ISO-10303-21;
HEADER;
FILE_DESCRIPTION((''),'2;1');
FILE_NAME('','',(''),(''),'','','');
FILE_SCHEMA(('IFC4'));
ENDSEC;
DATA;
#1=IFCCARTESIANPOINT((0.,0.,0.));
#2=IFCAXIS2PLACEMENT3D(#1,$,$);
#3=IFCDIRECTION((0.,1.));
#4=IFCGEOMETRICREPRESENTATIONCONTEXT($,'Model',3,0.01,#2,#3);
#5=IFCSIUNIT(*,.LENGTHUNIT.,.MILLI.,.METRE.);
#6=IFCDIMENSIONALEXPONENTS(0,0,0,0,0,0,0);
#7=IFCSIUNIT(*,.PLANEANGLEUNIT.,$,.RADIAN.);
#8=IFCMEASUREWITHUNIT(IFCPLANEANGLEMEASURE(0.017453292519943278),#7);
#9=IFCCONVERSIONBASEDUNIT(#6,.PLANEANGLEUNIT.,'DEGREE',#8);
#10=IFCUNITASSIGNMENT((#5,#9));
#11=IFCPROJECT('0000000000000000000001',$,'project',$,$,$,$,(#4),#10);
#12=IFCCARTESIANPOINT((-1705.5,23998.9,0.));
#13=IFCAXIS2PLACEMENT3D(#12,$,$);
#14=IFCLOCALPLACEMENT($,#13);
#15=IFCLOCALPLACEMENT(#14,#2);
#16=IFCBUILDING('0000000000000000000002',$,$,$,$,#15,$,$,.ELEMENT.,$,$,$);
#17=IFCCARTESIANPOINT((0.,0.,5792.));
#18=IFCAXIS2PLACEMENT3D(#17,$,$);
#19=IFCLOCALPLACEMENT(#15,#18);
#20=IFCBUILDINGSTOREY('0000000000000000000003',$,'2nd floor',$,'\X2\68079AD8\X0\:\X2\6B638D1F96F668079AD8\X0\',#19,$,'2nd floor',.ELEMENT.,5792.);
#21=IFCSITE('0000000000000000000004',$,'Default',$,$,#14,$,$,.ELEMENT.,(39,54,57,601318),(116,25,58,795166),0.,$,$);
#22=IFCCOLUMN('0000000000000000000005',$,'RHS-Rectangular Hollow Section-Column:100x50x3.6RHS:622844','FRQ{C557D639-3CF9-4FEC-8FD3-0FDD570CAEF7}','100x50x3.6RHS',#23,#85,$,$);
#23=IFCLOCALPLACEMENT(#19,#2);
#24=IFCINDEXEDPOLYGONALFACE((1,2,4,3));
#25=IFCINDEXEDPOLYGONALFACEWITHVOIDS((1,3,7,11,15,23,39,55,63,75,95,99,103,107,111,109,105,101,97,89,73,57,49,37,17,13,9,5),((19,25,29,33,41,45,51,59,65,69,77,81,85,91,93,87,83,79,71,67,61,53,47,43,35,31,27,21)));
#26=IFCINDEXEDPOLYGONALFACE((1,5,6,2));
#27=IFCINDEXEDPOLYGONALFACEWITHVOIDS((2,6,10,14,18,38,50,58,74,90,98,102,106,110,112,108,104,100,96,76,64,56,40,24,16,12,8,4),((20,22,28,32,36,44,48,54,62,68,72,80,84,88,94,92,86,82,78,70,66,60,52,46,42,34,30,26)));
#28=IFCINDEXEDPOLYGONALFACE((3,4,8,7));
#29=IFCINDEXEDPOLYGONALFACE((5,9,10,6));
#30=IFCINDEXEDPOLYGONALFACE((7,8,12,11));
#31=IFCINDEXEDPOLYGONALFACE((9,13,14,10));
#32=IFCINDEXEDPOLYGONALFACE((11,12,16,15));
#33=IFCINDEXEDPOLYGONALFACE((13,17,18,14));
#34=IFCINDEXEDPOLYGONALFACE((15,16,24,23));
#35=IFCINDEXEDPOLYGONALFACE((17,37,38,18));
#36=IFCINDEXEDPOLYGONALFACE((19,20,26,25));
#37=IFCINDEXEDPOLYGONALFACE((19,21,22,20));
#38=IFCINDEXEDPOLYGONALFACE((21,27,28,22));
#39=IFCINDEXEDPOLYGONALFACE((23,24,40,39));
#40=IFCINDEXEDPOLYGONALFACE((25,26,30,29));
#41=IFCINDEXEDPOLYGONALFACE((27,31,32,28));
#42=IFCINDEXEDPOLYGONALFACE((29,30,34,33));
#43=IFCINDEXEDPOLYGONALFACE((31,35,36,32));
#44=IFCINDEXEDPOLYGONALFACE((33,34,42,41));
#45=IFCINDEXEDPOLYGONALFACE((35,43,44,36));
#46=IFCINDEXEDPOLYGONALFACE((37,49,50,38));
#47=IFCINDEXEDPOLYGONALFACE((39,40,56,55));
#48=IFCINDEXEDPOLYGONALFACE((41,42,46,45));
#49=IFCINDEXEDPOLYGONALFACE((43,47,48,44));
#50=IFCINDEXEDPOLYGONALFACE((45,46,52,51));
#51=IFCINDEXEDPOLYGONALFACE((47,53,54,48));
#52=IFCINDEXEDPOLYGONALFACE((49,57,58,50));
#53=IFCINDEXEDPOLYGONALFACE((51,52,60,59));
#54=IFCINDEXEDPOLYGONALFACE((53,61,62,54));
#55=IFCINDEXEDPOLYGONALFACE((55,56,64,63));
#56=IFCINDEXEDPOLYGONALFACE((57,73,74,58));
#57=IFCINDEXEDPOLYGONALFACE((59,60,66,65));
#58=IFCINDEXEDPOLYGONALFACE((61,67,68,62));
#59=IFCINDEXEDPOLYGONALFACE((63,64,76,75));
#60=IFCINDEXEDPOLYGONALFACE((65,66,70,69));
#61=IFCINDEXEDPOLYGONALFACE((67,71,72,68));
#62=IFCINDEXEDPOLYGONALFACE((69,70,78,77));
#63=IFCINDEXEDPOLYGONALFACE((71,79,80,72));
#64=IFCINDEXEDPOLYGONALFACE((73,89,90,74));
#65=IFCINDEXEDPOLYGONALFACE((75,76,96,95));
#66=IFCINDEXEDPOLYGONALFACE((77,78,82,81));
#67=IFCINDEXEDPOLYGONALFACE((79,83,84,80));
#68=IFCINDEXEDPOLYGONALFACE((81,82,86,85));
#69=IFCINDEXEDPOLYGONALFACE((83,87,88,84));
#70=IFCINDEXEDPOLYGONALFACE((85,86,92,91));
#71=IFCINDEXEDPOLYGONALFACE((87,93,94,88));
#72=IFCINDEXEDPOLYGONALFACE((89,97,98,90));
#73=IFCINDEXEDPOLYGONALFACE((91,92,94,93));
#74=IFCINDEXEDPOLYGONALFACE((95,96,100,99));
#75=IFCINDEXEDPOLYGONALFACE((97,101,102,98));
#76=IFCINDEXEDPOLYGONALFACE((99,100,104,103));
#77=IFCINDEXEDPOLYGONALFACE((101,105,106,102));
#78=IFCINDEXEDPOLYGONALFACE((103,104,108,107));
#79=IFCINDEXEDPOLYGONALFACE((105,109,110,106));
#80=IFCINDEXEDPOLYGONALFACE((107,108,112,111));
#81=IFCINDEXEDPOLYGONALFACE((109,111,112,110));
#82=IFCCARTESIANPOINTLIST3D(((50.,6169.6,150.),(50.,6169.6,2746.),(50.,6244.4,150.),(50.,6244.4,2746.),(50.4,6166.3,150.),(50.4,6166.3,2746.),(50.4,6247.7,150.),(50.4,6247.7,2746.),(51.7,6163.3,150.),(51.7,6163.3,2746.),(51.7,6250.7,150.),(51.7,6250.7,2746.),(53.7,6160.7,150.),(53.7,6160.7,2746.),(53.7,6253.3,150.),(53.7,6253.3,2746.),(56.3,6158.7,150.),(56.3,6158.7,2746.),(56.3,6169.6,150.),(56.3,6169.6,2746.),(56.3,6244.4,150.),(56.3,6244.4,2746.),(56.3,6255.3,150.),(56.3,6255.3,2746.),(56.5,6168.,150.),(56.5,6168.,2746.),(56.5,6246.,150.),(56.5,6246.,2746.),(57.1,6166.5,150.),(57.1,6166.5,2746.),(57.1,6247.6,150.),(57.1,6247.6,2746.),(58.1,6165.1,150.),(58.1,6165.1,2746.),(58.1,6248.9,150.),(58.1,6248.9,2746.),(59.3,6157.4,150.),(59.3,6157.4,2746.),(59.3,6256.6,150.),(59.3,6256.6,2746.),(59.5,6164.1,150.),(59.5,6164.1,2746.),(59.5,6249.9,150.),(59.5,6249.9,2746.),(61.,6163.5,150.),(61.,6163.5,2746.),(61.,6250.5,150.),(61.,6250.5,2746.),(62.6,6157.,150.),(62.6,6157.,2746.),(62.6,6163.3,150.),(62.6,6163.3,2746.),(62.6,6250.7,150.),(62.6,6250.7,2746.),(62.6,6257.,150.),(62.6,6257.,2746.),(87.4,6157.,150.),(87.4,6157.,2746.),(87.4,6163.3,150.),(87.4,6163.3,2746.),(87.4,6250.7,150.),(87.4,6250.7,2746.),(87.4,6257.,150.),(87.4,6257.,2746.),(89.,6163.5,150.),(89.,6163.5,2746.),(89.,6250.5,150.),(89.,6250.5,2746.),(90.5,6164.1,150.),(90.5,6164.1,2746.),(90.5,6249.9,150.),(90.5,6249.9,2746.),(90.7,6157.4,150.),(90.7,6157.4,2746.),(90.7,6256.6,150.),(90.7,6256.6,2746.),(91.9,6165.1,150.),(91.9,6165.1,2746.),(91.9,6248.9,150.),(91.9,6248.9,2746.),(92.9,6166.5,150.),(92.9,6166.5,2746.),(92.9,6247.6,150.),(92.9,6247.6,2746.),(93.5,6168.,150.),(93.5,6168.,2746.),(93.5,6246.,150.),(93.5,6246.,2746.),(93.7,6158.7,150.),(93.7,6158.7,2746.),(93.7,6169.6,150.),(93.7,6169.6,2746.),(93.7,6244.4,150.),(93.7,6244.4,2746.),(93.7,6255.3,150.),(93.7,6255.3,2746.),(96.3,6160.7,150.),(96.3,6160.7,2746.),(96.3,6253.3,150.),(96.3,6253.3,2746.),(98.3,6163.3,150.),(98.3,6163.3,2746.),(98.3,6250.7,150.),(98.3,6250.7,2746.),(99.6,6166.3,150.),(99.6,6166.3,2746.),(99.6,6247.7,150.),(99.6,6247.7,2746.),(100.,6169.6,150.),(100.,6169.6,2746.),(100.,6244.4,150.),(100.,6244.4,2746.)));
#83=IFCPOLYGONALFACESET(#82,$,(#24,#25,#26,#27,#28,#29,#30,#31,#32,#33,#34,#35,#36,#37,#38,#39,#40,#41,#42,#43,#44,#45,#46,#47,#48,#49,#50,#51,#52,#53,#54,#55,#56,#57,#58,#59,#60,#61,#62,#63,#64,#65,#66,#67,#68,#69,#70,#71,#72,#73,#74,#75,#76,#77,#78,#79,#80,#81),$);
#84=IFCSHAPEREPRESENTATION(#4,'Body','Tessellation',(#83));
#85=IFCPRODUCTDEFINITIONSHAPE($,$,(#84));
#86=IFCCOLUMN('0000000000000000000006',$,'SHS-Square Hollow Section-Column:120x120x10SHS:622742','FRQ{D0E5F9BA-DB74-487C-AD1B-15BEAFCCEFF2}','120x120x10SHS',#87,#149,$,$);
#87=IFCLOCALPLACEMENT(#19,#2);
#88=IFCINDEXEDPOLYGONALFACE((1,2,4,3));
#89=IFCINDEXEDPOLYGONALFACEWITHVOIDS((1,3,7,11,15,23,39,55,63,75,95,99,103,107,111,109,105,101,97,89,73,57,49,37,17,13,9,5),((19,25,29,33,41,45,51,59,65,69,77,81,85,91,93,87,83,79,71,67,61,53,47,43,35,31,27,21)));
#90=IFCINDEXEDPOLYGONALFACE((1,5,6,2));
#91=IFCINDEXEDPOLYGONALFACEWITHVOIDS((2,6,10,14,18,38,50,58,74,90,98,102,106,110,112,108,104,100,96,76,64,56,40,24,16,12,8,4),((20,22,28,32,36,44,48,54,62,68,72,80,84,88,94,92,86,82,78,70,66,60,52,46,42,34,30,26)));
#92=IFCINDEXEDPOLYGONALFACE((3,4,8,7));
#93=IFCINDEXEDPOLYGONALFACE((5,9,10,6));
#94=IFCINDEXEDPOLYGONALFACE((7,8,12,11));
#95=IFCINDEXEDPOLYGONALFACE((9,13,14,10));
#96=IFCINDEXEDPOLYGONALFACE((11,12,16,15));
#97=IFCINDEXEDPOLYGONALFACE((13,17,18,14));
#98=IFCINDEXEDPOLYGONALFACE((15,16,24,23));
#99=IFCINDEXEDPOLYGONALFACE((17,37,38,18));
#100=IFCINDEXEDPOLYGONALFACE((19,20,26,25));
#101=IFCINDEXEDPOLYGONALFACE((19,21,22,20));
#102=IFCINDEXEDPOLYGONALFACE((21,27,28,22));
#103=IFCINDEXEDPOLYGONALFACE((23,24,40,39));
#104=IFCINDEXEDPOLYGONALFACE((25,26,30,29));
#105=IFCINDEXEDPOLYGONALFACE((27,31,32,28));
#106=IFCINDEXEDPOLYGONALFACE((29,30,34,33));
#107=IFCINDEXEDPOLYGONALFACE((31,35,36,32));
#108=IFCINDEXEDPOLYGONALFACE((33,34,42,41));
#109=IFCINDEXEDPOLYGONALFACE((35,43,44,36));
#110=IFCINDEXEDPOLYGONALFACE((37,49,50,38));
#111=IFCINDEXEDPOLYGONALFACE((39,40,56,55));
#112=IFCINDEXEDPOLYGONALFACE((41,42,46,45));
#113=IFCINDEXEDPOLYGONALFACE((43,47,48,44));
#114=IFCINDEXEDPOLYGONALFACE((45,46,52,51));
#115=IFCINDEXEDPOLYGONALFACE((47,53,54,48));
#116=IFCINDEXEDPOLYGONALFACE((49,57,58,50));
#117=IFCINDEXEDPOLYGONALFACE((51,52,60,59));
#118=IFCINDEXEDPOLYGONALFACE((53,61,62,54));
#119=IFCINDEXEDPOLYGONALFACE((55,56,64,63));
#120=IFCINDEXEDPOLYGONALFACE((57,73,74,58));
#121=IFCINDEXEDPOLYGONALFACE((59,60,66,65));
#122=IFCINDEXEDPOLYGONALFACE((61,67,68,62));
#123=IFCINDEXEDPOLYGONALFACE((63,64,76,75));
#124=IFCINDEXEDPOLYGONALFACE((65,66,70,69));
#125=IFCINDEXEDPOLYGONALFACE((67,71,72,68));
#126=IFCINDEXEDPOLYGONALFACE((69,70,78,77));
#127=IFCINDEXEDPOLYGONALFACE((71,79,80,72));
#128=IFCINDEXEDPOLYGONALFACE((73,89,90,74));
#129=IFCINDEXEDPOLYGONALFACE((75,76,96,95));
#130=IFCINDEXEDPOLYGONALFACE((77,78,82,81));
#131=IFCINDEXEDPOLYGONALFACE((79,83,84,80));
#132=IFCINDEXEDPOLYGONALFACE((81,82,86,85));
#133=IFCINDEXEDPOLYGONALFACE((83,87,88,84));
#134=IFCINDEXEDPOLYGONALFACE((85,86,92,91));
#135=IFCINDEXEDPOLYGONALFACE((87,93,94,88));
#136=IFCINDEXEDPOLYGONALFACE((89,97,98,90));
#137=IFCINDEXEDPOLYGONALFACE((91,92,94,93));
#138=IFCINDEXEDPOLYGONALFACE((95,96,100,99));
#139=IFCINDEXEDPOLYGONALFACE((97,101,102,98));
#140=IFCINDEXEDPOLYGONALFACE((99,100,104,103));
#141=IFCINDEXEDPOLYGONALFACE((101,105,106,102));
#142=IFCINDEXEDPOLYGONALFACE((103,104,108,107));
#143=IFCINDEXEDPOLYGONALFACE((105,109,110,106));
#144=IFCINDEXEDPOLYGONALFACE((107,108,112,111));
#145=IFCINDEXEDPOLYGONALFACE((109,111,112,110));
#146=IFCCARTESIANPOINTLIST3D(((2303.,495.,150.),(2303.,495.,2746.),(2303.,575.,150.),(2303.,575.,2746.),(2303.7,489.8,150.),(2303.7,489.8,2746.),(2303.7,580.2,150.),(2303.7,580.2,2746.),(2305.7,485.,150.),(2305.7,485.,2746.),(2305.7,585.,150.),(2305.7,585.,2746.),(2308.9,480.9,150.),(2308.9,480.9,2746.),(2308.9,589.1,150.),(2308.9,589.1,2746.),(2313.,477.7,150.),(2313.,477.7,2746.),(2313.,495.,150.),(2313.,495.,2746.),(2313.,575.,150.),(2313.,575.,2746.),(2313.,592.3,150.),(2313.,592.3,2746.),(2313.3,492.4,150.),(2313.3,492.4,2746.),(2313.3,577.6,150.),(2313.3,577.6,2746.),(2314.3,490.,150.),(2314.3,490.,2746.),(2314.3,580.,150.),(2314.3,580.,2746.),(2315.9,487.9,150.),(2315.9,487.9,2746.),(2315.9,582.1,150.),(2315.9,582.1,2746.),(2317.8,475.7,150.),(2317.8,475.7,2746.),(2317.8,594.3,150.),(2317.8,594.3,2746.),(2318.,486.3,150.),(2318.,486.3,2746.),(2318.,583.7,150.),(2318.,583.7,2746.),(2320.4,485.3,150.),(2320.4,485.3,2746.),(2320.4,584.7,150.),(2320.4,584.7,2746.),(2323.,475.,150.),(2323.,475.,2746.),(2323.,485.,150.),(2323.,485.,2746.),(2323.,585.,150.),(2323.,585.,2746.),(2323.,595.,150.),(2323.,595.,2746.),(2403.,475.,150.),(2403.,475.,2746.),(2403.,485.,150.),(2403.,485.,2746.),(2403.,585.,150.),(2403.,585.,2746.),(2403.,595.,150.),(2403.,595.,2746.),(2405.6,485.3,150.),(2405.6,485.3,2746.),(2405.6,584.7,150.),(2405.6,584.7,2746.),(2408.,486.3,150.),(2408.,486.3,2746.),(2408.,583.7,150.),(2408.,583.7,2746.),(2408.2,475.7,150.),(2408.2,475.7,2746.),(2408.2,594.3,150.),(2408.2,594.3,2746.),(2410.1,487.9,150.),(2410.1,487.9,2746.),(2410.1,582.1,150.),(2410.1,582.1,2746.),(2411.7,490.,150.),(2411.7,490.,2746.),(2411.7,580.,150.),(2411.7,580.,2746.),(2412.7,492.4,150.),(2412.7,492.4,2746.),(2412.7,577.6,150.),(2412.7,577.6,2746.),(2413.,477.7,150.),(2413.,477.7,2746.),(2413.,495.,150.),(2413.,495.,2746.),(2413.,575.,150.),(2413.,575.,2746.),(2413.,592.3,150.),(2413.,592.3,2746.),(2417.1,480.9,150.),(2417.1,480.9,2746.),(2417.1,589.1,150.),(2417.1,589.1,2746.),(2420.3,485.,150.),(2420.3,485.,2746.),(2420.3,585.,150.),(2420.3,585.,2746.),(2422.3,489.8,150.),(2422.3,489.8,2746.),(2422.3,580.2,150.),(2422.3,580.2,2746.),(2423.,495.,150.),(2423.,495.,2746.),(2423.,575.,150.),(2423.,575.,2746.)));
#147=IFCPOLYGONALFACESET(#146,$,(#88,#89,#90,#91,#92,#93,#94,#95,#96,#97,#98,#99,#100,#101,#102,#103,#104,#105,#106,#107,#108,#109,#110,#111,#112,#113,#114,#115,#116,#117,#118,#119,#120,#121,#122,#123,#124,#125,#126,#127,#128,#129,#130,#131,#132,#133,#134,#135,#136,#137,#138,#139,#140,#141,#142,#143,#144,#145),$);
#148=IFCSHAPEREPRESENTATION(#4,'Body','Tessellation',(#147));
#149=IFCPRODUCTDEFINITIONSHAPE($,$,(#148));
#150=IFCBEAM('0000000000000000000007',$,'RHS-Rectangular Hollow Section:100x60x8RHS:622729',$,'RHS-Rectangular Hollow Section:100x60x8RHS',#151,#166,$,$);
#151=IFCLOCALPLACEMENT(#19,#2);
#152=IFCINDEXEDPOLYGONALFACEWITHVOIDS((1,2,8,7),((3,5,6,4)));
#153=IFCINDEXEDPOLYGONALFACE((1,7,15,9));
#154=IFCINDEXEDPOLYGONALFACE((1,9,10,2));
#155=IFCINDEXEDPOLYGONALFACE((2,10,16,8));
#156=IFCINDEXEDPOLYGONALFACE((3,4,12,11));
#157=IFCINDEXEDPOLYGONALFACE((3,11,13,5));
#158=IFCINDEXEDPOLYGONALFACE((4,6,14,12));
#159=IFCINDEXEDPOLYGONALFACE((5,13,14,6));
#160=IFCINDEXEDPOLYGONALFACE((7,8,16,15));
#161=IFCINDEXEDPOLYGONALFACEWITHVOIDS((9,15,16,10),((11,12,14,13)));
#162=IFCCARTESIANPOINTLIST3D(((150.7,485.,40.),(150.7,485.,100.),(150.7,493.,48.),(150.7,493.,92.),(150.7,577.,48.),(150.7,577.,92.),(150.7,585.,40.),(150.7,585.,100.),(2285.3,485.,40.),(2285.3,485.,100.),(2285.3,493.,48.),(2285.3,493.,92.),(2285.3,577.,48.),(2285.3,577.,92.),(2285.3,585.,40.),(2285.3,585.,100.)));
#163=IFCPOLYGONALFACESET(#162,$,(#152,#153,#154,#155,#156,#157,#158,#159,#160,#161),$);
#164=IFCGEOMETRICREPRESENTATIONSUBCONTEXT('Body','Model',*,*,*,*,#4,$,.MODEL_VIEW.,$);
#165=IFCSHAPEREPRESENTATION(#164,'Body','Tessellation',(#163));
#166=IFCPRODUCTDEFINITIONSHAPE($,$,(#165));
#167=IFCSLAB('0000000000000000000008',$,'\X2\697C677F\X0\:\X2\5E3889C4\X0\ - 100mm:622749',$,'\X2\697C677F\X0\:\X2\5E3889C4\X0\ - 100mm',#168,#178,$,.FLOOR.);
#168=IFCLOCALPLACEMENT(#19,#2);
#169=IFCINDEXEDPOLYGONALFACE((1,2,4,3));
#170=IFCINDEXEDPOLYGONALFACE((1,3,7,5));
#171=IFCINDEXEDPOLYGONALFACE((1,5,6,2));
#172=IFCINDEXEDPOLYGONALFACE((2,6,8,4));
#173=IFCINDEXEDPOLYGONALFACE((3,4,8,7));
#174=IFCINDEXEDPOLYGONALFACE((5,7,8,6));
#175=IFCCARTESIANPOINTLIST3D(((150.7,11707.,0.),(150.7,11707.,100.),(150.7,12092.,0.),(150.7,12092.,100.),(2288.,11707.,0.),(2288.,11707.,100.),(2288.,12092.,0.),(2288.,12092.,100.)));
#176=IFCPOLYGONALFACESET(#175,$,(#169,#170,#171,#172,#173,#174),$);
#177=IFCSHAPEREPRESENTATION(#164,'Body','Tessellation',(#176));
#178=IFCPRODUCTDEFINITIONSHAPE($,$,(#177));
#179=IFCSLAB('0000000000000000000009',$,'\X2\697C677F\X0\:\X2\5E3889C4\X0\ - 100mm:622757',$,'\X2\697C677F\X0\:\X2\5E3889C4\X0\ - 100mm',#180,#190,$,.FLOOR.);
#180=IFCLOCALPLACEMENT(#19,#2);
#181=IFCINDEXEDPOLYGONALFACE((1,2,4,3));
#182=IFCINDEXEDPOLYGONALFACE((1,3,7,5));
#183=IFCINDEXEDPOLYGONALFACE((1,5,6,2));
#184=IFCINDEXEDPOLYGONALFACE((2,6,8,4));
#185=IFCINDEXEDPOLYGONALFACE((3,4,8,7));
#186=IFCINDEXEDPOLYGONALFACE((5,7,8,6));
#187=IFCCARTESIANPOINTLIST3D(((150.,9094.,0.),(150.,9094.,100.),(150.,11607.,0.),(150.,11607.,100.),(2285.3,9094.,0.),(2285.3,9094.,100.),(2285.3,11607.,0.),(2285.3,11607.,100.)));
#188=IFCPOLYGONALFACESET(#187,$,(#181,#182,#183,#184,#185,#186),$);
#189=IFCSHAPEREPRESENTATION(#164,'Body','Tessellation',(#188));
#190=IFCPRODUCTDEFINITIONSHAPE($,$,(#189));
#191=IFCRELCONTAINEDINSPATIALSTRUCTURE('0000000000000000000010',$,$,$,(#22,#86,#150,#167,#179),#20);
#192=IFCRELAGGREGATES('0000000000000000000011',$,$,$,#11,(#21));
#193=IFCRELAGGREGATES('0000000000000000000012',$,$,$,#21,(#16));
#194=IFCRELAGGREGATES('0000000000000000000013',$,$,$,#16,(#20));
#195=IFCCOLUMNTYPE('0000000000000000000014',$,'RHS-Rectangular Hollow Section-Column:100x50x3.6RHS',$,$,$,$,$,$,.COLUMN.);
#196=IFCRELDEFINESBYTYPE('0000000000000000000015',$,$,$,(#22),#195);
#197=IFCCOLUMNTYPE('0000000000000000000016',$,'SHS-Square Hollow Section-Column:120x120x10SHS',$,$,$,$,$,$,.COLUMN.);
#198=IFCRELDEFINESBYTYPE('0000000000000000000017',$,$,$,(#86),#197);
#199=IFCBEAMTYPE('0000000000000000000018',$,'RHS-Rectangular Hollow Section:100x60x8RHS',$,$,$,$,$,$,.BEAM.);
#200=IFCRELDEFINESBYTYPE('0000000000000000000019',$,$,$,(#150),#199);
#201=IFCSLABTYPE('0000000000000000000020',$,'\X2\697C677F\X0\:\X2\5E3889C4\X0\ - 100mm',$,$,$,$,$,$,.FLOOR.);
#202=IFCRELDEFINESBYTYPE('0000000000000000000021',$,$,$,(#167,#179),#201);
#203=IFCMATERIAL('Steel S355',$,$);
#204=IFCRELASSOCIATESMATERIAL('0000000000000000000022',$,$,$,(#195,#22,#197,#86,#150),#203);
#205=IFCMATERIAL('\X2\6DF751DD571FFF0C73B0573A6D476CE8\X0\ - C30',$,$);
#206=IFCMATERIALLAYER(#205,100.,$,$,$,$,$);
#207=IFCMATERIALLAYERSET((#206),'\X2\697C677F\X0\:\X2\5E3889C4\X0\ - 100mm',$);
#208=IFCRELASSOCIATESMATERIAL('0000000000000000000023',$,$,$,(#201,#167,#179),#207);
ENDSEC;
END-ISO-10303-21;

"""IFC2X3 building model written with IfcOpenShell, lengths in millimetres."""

from ifc_helpers import new_model, entity, si_unit, converted_unit, direction, frame, frame_2d, origin, origin_2d, origin_2d_with_axis, place, context, subcontext, project, spatial, rectangle, hollow_rectangle, extrude, boolean, clip, halfspace, material, layer, layer_set, layer_usage, type_object, element, save


model = new_model("IFC2X3")

# Units and contexts
model_context = context("Model", 3, precision=0.01, world=origin(), true_north=direction((0.0, 1.0)))
body_context = subcontext(model_context, "Body", "Model", "MODEL_VIEW")
ifc_project = project(units=[si_unit("LENGTHUNIT", "METRE", prefix="MILLI"), converted_unit("PLANEANGLEUNIT", "DEGREE", entity("IfcPlaneAngleMeasure", 0.017453292519943278), si_unit("PLANEANGLEUNIT", "RADIAN"), dimensions=[0, 0, 0, 0, 0, 0, 0])], contexts=[model_context])

# Site, building, storey
site_placement = place(None, frame((-1705.5, 23998.9, 0.0)))
site = spatial("IfcSite", under=ifc_project, at=site_placement, Name="Default", CompositionType="ELEMENT", RefLatitude=(39, 54, 57, 601318), RefLongitude=(116, 25, 58, 795166), RefElevation=0.0)
building_placement = place(site_placement, origin())
building = spatial("IfcBuilding", under=site, at=building_placement, CompositionType="ELEMENT")
storey_placement = place(building_placement, frame((0.0, 0.0, 5792.0)))
storey = spatial("IfcBuildingStorey", under=building, at=storey_placement, Name="2nd floor", ObjectType="标高:正负零标高", LongName="2nd floor", CompositionType="ELEMENT", Elevation=5792.0)

# Shared definitions
ifc_material_1 = material(Name="Steel S355")

# Columns
column_type_1 = type_object("IfcColumnType", Name="RHS-Rectangular Hollow Section-Column:100x50x3.6RHS", PredefinedType="COLUMN", material=ifc_material_1)
column_1_placement = place(storey_placement, frame((75.0, 6207.0, 2746.0), z_axis=(0.0, 0.0, 1.0), x_axis=(-1.0, 0.0, 0.0)))
element("IfcColumn", 1, at=column_1_placement, inside=storey, type_object=column_type_1, material=ifc_material_1, Name="RHS-Rectangular Hollow Section-Column:100x50x3.6RHS:622844", Description="FRQ{C557D639-3CF9-4FEC-8FD3-0FDD570CAEF7}", ObjectType="100x50x3.6RHS", context=model_context, shape_type="Clipping", body=[
    clip(extrude(hollow_rectangle(XDim=50.0, YDim=100.0, WallThickness=6.3, InnerFilletRadius=6.3, OuterFilletRadius=12.6, at=origin_2d()), origin(), (0.0, 0.0, -1.0), 2651.9), halfspace(frame((75.0, 6207.0, -2596.0), z_axis=(0.0, 0.0, 1.0), x_axis=(-1.0, 0.0, 0.0)), True)),
])
column_type_2 = type_object("IfcColumnType", Name="SHS-Square Hollow Section-Column:120x120x10SHS", PredefinedType="COLUMN", material=ifc_material_1)
column_2_placement = place(storey_placement, frame((2363.0, 535.0, 2746.0), z_axis=(0.0, 0.0, 1.0), x_axis=(0.0, -1.0, 0.0)))
element("IfcColumn", 2, at=column_2_placement, inside=storey, type_object=column_type_2, material=ifc_material_1, Name="SHS-Square Hollow Section-Column:120x120x10SHS:622742", Description="FRQ{D0E5F9BA-DB74-487C-AD1B-15BEAFCCEFF2}", ObjectType="120x120x10SHS", context=model_context, shape_type="Clipping", body=[
    clip(extrude(hollow_rectangle(XDim=120.0, YDim=120.0, WallThickness=10.0, InnerFilletRadius=10.0, OuterFilletRadius=20.0, at=origin_2d()), origin(), (0.0, 0.0, -1.0), 2680.9), halfspace(frame((535.0, -2363.0, -2596.0), z_axis=(0.0, 0.0, 1.0), x_axis=(0.0, 1.0, 0.0)), True)),
])

# Beam
beam_type_1 = type_object("IfcBeamType", Name="RHS-Rectangular Hollow Section:100x60x8RHS", PredefinedType="BEAM")
beam_1_placement = place(storey_placement, frame((150.7, 585.0, 70.0)))
element("IfcBeam", 3, at=beam_1_placement, inside=storey, type_object=beam_type_1, material=ifc_material_1, Name="RHS-Rectangular Hollow Section:100x60x8RHS:622729", ObjectType="RHS-Rectangular Hollow Section:100x60x8RHS", context=body_context, shape_type="SweptSolid", body=[
    boolean("DIFFERENCE", extrude(rectangle(XDim=60.0, YDim=100.0, at=frame_2d((0.0, 0.0), x_axis=(1.0, 0.0))), frame((0.0, -50.0, 0.0), z_axis=(1.0, 0.0, 0.0), x_axis=(0.0, 0.0, -1.0)), (0.0, 0.0, 1.0), 2134.6), extrude(rectangle(XDim=44.0, YDim=84.0, at=frame_2d((0.0, 0.0), x_axis=(0.0, 1.0))), frame((2134.6, -50.0, 0.0), z_axis=(-1.0, 0.0, 0.0), x_axis=(0.0, 1.0, 0.0)), (0.0, 0.0, 1.0), 2134.6)),
])

# Slabs
ifc_material_2 = material(Name="混凝土，现场浇注 - C30")
ifc_layer_1 = layer(ifc_material_2, 100.0)
ifc_layer_set_1 = layer_set([ifc_layer_1], Name="楼板:常规 - 100mm")
ifc_layer_usage_1 = layer_usage(ifc_layer_set_1, "AXIS3", "POSITIVE", 0.0)
slab_type = type_object("IfcSlabType", Name="楼板:常规 - 100mm", PredefinedType="FLOOR", material=ifc_layer_set_1)
slab_1_placement = place(storey_placement, origin())
element("IfcSlab", 4, at=slab_1_placement, inside=storey, type_object=slab_type, material=ifc_layer_usage_1, Name="楼板:常规 - 100mm:622749", ObjectType="楼板:常规 - 100mm", PredefinedType="FLOOR", context=body_context, shape_type="SweptSolid", body=[
    extrude(rectangle(XDim=385.0, YDim=2137.3, at=origin_2d_with_axis()), frame((1219.3, 11899.5, 100.0), z_axis=(0.0, 0.0, -1.0), x_axis=(0.0, 1.0, 0.0)), (0.0, 0.0, 1.0), 100.0),
])
ifc_layer_usage_2 = layer_usage(ifc_layer_set_1, "AXIS3", "POSITIVE", 0.0)
slab_2_placement = place(storey_placement, origin())
element("IfcSlab", 5, at=slab_2_placement, inside=storey, type_object=slab_type, material=ifc_layer_usage_2, Name="楼板:常规 - 100mm:622757", ObjectType="楼板:常规 - 100mm", PredefinedType="FLOOR", context=body_context, shape_type="SweptSolid", body=[
    extrude(rectangle(XDim=2513.0, YDim=2135.3, at=frame_2d((0.0, 0.0), x_axis=(1.0, 0.0))), frame((1217.6, 10350.5, 100.0), z_axis=(0.0, 0.0, -1.0), x_axis=(0.0, 1.0, 0.0)), (0.0, 0.0, 1.0), 100.0),
])

save(model, "model.ifc")
